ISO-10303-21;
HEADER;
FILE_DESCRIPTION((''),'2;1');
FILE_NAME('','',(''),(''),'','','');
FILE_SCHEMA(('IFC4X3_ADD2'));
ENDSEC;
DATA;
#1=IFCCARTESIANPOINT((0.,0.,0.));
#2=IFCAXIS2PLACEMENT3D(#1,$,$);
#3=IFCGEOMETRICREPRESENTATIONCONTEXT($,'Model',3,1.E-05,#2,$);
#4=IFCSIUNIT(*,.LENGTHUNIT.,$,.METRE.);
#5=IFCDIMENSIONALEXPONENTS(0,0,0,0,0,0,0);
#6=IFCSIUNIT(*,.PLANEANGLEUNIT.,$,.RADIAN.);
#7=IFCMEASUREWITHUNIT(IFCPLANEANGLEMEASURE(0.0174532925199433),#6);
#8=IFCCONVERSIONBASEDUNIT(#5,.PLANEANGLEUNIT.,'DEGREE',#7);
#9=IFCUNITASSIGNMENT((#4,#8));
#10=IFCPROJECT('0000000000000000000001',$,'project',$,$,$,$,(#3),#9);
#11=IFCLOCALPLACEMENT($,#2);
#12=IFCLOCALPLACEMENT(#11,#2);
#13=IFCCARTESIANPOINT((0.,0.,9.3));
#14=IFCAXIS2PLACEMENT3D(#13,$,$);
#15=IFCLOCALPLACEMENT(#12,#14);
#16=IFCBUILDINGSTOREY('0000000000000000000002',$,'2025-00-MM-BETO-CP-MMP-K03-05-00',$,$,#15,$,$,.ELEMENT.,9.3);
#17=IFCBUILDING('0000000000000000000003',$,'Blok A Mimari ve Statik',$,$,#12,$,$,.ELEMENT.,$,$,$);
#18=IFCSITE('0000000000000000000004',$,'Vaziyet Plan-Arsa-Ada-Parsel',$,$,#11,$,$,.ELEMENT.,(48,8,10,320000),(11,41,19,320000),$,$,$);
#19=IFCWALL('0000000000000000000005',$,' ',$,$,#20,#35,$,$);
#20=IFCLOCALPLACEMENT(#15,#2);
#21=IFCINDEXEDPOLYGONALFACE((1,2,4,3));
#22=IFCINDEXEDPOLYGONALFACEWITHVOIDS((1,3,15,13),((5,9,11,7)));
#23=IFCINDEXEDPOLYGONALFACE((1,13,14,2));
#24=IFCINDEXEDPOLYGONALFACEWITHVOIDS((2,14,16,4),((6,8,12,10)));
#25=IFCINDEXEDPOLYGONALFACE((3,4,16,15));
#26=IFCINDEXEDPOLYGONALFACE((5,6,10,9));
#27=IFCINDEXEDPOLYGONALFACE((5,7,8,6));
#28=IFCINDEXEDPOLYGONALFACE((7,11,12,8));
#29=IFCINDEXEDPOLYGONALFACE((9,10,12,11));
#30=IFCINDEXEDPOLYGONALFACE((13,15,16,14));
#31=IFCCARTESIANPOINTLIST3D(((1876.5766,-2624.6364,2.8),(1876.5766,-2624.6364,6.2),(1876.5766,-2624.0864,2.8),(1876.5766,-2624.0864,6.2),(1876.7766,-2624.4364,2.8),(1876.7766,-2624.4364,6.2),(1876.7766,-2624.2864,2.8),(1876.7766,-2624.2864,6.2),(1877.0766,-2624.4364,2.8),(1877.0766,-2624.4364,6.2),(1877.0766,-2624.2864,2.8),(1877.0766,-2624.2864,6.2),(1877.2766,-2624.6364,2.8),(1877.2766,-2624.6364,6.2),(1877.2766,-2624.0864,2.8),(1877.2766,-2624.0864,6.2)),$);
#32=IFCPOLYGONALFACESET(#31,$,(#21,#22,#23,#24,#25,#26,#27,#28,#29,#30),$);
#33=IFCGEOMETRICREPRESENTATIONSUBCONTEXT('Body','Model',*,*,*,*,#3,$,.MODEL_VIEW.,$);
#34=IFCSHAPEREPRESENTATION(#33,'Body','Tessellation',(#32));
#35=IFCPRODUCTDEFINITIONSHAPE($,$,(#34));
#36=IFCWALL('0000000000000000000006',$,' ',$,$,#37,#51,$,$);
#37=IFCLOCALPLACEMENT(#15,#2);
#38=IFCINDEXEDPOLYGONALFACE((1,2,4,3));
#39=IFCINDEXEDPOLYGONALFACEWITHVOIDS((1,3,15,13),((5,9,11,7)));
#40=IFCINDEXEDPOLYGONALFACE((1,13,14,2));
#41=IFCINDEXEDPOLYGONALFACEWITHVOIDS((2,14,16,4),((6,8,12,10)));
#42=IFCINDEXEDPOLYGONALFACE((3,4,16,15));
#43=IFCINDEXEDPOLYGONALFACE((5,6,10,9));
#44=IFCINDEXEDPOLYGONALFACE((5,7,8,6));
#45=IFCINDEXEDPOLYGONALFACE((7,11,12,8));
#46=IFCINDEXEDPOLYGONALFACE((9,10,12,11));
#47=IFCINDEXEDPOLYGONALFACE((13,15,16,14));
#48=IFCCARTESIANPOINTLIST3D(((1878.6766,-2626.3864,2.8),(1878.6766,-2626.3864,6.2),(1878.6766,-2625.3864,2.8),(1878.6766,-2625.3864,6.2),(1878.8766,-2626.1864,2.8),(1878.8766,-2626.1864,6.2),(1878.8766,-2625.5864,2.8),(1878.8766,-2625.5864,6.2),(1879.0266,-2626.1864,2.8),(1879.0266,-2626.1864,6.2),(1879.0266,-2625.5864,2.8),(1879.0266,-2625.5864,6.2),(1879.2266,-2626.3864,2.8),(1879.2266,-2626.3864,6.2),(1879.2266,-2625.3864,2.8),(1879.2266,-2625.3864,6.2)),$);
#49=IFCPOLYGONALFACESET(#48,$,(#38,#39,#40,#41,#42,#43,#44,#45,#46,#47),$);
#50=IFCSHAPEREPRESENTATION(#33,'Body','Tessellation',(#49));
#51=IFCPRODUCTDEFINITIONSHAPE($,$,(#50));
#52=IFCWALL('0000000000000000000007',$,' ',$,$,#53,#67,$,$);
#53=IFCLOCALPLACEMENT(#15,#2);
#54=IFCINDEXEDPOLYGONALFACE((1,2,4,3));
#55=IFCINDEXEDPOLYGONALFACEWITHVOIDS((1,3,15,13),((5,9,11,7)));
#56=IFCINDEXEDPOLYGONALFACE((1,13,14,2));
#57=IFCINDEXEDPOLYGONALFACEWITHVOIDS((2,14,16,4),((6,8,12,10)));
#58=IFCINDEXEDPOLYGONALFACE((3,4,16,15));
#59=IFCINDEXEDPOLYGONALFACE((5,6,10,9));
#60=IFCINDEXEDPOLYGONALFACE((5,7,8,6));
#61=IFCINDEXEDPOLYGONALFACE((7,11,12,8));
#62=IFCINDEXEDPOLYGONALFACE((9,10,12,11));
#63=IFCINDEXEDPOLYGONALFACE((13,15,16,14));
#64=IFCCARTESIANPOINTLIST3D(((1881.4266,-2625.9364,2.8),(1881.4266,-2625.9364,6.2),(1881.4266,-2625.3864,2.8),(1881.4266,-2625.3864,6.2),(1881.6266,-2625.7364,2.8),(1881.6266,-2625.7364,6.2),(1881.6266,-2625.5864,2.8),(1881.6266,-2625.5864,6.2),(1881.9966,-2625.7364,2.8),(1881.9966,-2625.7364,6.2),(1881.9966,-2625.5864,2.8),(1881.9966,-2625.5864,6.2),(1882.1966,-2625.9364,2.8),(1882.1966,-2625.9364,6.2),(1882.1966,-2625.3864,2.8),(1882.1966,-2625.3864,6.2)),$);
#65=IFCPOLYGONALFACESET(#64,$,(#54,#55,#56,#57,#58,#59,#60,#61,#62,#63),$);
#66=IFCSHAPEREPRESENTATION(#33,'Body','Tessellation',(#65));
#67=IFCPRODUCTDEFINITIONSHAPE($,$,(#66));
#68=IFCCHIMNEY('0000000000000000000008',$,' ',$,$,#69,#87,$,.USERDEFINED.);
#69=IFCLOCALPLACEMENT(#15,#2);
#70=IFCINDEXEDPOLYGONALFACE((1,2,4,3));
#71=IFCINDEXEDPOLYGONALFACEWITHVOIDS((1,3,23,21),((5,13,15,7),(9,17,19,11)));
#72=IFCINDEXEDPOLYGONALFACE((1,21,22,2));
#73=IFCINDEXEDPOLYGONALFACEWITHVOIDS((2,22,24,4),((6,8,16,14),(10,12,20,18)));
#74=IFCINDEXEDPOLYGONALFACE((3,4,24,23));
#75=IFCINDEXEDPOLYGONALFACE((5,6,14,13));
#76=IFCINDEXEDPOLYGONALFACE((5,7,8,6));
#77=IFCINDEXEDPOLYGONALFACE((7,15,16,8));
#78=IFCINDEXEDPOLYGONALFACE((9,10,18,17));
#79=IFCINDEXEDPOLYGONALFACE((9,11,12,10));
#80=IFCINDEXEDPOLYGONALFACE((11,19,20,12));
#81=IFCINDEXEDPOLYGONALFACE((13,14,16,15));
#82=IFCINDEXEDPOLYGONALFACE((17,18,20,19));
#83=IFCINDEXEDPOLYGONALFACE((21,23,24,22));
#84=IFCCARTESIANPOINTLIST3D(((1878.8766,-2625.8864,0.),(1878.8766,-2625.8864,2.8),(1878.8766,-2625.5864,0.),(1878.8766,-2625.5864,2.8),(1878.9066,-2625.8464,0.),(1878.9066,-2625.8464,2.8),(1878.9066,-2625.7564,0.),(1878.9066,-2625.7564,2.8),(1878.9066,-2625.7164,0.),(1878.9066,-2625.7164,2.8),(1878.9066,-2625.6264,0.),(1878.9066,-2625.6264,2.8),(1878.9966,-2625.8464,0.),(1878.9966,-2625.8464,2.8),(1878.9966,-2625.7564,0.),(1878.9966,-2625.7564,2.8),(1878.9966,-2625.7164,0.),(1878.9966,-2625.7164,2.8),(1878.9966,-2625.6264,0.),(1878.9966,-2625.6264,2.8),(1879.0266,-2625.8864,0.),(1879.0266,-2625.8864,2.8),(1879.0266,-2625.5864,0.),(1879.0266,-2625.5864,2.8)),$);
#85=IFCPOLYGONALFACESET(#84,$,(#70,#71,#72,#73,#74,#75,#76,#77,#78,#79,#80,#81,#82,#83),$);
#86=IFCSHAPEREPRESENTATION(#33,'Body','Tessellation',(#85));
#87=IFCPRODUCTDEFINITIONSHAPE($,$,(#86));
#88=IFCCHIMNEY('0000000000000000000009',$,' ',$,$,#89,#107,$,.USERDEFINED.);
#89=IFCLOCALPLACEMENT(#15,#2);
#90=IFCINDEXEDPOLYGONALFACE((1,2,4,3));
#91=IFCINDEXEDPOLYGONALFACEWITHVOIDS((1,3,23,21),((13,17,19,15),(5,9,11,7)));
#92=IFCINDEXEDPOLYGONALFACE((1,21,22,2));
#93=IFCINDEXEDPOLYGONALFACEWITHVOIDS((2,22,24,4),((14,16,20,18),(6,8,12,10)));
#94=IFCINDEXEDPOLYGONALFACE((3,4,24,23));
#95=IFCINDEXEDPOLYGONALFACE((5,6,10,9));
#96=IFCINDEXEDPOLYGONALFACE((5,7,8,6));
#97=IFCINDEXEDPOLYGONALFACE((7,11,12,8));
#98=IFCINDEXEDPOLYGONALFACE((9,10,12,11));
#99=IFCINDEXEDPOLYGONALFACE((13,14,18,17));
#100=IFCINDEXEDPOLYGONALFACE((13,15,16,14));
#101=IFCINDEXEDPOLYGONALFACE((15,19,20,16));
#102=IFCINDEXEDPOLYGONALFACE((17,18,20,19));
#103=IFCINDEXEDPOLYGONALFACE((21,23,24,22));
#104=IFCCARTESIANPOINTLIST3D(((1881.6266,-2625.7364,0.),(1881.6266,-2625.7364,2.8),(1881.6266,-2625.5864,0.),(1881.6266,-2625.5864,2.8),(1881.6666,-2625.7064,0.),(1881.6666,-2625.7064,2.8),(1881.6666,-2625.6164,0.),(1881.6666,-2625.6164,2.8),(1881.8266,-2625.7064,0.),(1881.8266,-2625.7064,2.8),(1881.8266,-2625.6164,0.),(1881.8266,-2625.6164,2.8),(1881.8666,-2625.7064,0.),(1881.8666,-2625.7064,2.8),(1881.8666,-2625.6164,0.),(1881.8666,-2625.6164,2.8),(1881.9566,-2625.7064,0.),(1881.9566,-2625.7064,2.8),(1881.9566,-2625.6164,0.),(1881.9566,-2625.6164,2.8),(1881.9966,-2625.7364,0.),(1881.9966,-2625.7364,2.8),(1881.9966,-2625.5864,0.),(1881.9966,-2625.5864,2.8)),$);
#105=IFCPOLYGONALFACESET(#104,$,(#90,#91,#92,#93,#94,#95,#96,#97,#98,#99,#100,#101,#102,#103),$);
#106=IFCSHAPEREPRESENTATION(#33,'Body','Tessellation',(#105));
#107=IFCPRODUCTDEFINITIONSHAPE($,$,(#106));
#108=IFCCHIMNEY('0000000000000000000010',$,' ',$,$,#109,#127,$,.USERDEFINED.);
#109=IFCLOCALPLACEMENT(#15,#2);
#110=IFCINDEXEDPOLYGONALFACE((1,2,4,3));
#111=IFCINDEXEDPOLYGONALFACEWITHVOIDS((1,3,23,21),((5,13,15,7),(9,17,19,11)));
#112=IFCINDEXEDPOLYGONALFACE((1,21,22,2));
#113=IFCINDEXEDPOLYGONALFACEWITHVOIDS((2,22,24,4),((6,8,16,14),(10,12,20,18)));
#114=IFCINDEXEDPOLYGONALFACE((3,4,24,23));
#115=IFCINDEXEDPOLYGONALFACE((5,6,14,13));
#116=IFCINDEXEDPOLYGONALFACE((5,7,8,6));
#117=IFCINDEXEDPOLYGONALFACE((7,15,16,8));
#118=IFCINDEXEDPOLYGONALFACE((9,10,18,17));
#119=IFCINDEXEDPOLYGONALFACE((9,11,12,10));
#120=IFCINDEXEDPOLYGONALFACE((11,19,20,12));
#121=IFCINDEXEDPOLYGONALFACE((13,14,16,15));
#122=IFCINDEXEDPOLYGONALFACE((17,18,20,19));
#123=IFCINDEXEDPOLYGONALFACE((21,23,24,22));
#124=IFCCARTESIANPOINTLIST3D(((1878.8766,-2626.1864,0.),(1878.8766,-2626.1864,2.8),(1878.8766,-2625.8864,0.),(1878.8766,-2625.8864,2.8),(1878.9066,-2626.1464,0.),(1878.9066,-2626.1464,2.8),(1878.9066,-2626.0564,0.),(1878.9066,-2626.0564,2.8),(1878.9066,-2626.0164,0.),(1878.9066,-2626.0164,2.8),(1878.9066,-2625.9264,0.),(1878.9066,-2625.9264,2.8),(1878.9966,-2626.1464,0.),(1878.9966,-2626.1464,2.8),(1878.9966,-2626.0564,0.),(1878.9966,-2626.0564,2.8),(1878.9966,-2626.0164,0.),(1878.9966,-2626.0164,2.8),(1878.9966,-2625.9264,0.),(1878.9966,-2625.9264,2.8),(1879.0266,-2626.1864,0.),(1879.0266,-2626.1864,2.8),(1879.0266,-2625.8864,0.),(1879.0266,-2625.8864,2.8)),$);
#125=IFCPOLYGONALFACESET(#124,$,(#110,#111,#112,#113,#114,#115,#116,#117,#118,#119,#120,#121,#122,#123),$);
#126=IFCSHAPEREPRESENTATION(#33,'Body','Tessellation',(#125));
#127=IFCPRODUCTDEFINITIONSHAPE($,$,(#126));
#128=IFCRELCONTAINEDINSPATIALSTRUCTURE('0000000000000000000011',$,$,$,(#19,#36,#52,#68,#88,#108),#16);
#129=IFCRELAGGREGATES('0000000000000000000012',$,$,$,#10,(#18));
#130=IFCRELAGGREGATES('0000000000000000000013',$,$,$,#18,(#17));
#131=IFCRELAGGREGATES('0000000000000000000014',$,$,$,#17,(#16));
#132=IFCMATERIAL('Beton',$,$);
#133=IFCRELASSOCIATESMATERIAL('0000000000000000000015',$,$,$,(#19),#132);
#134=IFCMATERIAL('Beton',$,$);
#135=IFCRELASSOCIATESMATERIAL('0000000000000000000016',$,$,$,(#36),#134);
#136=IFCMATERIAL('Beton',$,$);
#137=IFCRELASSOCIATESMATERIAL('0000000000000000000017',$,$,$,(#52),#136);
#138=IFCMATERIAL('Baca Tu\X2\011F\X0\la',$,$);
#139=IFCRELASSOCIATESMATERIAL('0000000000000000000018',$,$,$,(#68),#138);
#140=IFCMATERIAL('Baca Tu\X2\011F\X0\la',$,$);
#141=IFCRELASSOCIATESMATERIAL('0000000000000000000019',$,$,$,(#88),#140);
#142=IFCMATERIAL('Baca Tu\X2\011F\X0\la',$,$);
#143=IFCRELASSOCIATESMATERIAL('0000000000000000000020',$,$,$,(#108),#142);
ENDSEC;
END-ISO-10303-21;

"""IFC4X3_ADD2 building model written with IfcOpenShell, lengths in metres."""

from ifc_helpers import new_model, entity, si_unit, converted_unit, frame, origin, origin_with_axes, place, context, subcontext, project, spatial, polyline, outline, extrude, material, element, save


model = new_model("IFC4X3_ADD2")

# Units and contexts
model_context = context("Model", 3, precision=1e-05, world=origin())
body_context = subcontext(model_context, "Body", "Model", "MODEL_VIEW")
ifc_project = project(units=[si_unit("LENGTHUNIT", "METRE"), converted_unit("PLANEANGLEUNIT", "DEGREE", entity("IfcPlaneAngleMeasure", 0.0174532925199433), si_unit("PLANEANGLEUNIT", "RADIAN"), dimensions=[0, 0, 0, 0, 0, 0, 0])], contexts=[model_context])

# Site, building, storey
site_placement = place(None, origin())
site = spatial("IfcSite", under=ifc_project, at=site_placement, Name="Vaziyet Plan-Arsa-Ada-Parsel", CompositionType="ELEMENT", RefLatitude=(48, 8, 10, 320000), RefLongitude=(11, 41, 19, 320000))
building_placement = place(site_placement, origin())
building = spatial("IfcBuilding", under=site, at=building_placement, Name="Blok A Mimari ve Statik", CompositionType="ELEMENT")
storey_placement = place(building_placement, frame((0.0, 0.0, 9.3)))
storey = spatial("IfcBuildingStorey", under=building, at=storey_placement, Name="2025-00-MM-BETO-CP-MMP-K03-05-00", CompositionType="ELEMENT", Elevation=9.3)

# Walls
ifc_material_1 = material(Name="Beton")
wall_1_placement = place(storey_placement, frame((1876.5766, -2624.6364, 2.8)))
element("IfcWall", 1, at=wall_1_placement, inside=storey, material=ifc_material_1, Name=" ", context=body_context, shape_type="SweptSolid", body=[
    extrude(outline(polyline([(0.0, 0.0), (0.7, 0.0), (0.7, 0.55), (0.0, 0.55), (0.0, 0.0)]), holes=[polyline([(0.2, 0.2), (0.2, 0.35), (0.5, 0.35), (0.5, 0.2), (0.2, 0.2)])]), origin_with_axes(), (0.0, 0.0, 1.0), 3.4),
])
ifc_material_2 = material(Name="Beton")
wall_2_placement = place(storey_placement, frame((1878.6766, -2626.3864, 2.8)))
element("IfcWall", 2, at=wall_2_placement, inside=storey, material=ifc_material_2, Name=" ", context=body_context, shape_type="SweptSolid", body=[
    extrude(outline(polyline([(0.0, 0.0), (0.55, 0.0), (0.55, 1.0), (0.0, 1.0), (0.0, 0.0)]), holes=[polyline([(0.2, 0.2), (0.2, 0.8), (0.35, 0.8), (0.35, 0.2), (0.2, 0.2)])]), origin_with_axes(), (0.0, 0.0, 1.0), 3.4),
])
ifc_material_3 = material(Name="Beton")
wall_3_placement = place(storey_placement, frame((1881.4266, -2625.9364, 2.8)))
element("IfcWall", 3, at=wall_3_placement, inside=storey, material=ifc_material_3, Name=" ", context=body_context, shape_type="SweptSolid", body=[
    extrude(outline(polyline([(0.0, 0.0), (0.77, 0.0), (0.77, 0.55), (0.0, 0.55), (0.0, 0.0)]), holes=[polyline([(0.2, 0.2), (0.2, 0.35), (0.57, 0.35), (0.57, 0.2), (0.2, 0.2)])]), origin_with_axes(), (0.0, 0.0, 1.0), 3.4),
])

# Chimneys
ifc_material_4 = material(Name="Baca Tuğla")
chimney_1_placement = place(storey_placement, frame((1878.8766, -2625.8864, 0.0)))
element("IfcChimney", 4, at=chimney_1_placement, inside=storey, material=ifc_material_4, Name=" ", PredefinedType="USERDEFINED", context=body_context, shape_type="SweptSolid", body=[
    extrude(outline(polyline([(0.15, 0.0), (0.15, 0.3), (0.0, 0.3), (0.0, 0.0), (0.15, 0.0)]), holes=[polyline([(0.12, 0.04), (0.03, 0.04), (0.03, 0.13), (0.12, 0.13), (0.12, 0.04)]), polyline([(0.12, 0.17), (0.03, 0.17), (0.03, 0.26), (0.12, 0.26), (0.12, 0.17)])]), origin_with_axes(), (0.0, 0.0, 1.0), 2.8),
])
ifc_material_5 = material(Name="Baca Tuğla")
chimney_2_placement = place(storey_placement, frame((1881.6266, -2625.7364, 0.0)))
element("IfcChimney", 5, at=chimney_2_placement, inside=storey, material=ifc_material_5, Name=" ", PredefinedType="USERDEFINED", context=body_context, shape_type="SweptSolid", body=[
    extrude(outline(polyline([(0.0, 0.0), (0.37, 0.0), (0.37, 0.15), (0.0, 0.15), (0.0, 0.0)]), holes=[polyline([(0.24, 0.03), (0.24, 0.12), (0.33, 0.12), (0.33, 0.03), (0.24, 0.03)]), polyline([(0.04, 0.03), (0.04, 0.12), (0.2, 0.12), (0.2, 0.03), (0.04, 0.03)])]), origin_with_axes(), (0.0, 0.0, 1.0), 2.8),
])
ifc_material_6 = material(Name="Baca Tuğla")
chimney_3_placement = place(storey_placement, frame((1878.8766, -2626.1864, 0.0)))
element("IfcChimney", 6, at=chimney_3_placement, inside=storey, material=ifc_material_6, Name=" ", PredefinedType="USERDEFINED", context=body_context, shape_type="SweptSolid", body=[
    extrude(outline(polyline([(0.15, 0.0), (0.15, 0.3), (0.0, 0.3), (0.0, 0.0), (0.15, 0.0)]), holes=[polyline([(0.12, 0.17), (0.03, 0.17), (0.03, 0.26), (0.12, 0.26), (0.12, 0.17)]), polyline([(0.12, 0.04), (0.03, 0.04), (0.03, 0.13), (0.12, 0.13), (0.12, 0.04)])]), origin_with_axes(), (0.0, 0.0, 1.0), 2.8),
])

save(model, "model.ifc")
